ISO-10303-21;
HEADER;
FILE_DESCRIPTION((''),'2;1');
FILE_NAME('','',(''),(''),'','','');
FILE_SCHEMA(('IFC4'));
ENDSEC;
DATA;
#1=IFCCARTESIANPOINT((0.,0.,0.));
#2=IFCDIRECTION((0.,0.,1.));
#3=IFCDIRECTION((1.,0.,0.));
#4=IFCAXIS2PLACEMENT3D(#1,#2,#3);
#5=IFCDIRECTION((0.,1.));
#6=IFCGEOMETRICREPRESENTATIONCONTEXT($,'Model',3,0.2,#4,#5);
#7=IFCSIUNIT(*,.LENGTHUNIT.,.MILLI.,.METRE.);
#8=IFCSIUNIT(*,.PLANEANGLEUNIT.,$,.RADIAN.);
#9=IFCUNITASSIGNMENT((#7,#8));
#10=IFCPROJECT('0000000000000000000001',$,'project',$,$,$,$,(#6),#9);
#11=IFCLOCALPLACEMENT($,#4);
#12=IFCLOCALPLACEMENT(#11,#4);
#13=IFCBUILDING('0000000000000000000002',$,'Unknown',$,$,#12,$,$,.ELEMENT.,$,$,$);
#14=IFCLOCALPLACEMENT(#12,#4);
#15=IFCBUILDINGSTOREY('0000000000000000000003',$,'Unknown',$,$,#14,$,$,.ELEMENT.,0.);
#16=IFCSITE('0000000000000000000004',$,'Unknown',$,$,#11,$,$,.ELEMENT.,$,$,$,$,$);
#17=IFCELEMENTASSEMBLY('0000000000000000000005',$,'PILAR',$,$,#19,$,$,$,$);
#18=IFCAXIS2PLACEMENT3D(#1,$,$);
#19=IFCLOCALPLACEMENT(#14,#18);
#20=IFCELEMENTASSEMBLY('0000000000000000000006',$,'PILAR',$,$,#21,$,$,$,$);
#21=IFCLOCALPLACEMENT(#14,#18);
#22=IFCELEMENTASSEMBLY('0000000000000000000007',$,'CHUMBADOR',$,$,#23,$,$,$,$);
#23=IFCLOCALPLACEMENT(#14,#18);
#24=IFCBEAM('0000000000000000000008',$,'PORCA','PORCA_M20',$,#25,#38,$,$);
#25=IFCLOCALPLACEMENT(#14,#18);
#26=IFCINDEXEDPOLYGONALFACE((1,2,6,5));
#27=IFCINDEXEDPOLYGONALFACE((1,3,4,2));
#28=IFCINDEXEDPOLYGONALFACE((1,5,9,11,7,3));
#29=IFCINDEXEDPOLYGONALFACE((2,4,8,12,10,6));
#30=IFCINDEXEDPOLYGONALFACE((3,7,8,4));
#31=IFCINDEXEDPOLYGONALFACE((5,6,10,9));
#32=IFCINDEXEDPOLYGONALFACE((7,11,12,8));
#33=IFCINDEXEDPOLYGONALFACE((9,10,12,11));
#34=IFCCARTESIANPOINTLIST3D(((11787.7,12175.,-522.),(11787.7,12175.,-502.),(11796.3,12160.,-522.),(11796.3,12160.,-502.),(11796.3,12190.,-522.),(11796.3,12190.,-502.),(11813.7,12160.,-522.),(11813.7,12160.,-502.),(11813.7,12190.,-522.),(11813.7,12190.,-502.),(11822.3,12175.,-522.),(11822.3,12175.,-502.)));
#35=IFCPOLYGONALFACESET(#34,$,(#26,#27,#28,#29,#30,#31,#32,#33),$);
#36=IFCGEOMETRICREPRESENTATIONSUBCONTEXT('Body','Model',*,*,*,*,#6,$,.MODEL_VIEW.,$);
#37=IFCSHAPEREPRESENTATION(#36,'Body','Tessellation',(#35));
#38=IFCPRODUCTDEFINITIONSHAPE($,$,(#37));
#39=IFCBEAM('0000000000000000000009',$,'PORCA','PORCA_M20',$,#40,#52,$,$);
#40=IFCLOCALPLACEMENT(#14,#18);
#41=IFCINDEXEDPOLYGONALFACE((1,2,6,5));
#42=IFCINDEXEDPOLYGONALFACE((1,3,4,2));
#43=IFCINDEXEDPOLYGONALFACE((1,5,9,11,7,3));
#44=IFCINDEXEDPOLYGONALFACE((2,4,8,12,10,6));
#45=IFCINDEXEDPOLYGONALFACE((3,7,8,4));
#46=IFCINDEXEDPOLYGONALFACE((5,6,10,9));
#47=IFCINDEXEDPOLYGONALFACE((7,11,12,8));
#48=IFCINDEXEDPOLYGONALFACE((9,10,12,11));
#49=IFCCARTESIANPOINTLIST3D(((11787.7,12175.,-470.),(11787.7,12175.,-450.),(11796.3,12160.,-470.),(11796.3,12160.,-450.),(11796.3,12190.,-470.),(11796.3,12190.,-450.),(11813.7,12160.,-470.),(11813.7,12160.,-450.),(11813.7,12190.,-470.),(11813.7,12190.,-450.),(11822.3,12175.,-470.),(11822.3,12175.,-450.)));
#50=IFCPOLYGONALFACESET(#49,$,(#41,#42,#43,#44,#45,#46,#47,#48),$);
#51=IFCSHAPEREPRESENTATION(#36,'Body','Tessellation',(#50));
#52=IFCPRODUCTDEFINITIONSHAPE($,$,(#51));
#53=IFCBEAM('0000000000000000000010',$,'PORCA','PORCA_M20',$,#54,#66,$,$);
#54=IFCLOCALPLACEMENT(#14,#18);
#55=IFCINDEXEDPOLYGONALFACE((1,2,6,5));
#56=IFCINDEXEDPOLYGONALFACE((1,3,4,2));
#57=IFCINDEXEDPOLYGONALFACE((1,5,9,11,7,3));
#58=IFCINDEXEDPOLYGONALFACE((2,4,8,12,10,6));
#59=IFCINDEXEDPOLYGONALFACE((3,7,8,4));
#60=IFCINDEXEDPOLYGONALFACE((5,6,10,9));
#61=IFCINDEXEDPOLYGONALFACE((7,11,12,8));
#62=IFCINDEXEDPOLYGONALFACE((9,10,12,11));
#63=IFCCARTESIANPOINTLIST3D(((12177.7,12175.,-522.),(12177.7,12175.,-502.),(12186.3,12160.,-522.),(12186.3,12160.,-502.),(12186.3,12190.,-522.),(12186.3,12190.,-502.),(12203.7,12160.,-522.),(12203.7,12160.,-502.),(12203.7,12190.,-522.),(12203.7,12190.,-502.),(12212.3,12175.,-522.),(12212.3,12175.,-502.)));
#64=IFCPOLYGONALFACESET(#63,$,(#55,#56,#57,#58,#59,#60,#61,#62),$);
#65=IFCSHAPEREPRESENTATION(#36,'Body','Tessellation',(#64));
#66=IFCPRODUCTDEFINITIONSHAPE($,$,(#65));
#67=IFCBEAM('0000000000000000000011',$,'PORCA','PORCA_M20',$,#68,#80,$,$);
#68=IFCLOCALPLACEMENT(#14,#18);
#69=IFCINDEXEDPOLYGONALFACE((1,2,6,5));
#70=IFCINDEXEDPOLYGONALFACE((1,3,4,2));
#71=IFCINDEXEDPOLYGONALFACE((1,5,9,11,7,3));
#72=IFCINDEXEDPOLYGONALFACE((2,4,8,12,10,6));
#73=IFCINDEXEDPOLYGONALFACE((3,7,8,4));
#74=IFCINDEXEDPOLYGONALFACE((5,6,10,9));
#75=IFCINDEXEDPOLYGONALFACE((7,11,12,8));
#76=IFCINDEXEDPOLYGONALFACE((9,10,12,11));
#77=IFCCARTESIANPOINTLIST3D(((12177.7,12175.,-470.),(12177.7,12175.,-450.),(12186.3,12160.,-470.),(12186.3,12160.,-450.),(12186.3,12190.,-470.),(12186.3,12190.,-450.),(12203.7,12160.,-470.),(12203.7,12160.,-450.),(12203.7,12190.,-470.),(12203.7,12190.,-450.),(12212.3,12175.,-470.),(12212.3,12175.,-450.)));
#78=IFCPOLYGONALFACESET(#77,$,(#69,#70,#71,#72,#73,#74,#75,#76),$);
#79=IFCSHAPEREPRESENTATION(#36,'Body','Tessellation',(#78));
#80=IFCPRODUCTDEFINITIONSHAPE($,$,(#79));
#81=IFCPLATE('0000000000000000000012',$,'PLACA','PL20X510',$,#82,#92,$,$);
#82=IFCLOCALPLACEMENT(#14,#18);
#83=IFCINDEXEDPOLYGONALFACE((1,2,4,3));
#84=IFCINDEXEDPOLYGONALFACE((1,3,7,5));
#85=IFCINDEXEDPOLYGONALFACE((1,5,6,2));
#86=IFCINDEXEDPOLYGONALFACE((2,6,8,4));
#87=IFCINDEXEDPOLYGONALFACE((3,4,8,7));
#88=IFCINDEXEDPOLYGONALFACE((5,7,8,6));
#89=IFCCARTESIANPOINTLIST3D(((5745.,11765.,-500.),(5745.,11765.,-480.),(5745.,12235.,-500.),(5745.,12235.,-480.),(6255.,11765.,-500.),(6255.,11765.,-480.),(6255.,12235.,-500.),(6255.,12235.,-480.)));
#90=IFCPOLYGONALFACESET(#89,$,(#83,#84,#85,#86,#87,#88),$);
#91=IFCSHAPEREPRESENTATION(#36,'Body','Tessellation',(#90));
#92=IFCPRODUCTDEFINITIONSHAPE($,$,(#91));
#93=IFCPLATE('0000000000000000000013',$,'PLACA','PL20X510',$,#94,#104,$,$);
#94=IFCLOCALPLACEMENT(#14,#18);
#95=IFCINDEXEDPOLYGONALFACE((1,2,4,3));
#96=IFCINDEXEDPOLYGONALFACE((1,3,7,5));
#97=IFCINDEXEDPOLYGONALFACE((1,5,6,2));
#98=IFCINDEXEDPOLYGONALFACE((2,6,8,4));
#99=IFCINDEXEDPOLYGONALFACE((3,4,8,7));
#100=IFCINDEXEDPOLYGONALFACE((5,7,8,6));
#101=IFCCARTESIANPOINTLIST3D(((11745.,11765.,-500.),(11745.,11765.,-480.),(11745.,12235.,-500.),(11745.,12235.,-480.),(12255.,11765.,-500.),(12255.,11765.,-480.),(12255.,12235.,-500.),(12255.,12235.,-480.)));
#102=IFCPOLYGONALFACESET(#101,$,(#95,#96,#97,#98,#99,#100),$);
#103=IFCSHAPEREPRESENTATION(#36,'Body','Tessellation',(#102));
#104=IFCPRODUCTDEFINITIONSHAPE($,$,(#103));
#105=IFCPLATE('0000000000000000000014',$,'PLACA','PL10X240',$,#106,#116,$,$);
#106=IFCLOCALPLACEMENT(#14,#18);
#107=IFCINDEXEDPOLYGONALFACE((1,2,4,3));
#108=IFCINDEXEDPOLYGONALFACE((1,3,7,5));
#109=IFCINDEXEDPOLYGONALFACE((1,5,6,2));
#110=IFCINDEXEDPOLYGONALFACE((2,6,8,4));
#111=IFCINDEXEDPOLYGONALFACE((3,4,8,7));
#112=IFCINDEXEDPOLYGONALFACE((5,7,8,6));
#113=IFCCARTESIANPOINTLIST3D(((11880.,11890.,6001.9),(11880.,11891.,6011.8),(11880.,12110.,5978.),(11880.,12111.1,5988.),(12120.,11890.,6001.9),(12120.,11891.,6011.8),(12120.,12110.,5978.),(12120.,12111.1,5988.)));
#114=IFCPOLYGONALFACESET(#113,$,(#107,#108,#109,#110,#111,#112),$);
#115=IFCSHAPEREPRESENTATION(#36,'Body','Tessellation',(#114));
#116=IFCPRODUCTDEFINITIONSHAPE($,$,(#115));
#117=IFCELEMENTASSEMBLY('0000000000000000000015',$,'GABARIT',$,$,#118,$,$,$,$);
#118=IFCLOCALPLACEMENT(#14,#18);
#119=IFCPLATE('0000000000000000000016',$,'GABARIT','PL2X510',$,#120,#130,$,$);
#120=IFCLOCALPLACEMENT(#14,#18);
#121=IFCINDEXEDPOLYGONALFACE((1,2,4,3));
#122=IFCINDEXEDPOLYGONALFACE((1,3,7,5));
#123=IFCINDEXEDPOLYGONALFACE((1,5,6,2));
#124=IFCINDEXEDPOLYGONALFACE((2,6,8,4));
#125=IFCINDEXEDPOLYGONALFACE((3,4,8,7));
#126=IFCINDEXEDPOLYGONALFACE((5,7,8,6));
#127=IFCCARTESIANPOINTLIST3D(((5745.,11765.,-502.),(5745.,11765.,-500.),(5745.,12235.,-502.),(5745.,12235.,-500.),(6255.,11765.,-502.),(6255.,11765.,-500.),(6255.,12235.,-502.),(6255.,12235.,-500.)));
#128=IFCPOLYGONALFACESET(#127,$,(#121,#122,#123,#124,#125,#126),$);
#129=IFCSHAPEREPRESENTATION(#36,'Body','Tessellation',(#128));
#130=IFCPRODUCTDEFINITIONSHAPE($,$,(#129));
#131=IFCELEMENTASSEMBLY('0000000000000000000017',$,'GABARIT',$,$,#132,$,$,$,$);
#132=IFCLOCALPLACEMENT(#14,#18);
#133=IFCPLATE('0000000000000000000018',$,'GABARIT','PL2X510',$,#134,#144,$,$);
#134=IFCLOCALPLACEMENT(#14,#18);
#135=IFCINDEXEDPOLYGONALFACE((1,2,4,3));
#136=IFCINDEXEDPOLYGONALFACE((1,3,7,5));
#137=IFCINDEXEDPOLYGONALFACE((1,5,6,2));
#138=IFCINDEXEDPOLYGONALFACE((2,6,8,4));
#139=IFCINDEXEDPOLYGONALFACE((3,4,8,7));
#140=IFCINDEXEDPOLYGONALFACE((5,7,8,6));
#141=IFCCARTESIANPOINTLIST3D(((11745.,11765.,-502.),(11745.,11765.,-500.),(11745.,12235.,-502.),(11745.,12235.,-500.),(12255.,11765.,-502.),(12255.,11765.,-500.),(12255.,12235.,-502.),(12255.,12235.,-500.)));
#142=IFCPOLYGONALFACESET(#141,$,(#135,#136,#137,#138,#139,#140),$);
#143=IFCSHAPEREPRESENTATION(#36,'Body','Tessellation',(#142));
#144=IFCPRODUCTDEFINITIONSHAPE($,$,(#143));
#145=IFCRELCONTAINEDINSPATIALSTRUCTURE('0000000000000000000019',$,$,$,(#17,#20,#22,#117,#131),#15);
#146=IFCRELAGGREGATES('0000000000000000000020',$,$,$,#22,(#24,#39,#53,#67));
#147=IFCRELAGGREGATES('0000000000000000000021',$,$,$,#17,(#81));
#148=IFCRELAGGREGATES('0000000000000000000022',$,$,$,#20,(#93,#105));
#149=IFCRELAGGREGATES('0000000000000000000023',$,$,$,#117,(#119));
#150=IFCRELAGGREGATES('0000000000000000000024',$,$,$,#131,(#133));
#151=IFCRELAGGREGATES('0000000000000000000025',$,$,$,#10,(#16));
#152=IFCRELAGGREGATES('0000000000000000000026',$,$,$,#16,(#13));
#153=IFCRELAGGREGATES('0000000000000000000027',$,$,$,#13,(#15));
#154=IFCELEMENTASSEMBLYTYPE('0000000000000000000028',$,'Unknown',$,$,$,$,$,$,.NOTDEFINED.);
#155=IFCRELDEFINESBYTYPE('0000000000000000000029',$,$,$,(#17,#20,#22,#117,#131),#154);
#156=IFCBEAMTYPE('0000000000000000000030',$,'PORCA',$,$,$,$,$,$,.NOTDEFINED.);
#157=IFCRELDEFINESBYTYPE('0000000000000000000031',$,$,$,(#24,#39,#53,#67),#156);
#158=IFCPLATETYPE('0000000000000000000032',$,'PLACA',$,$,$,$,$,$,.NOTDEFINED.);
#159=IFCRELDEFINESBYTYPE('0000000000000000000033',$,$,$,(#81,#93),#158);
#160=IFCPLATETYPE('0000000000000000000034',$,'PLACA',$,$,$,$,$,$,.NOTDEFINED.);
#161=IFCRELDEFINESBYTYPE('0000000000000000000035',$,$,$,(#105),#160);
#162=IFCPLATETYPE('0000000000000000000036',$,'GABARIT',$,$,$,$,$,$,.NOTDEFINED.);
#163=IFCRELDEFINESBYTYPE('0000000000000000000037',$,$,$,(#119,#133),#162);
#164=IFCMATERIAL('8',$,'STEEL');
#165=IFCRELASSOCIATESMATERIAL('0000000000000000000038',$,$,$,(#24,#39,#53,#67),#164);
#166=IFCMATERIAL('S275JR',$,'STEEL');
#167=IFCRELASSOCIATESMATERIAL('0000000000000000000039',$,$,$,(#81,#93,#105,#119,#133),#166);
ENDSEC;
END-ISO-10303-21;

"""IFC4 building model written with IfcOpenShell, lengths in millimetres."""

from ifc_helpers import new_model, si_unit, direction, frame, origin_with_axes, origin_2d_with_axis, place, context, subcontext, project, spatial, polyline, rectangle, outline, extrude, material, material_profile, profile_set, profile_usage, type_object, element, aggregate, save


model = new_model("IFC4")

# Units and contexts
model_context = context("Model", 3, precision=0.2, world=origin_with_axes(), true_north=direction((0.0, 1.0)))
body_context = subcontext(model_context, "Body", "Model", "MODEL_VIEW")
ifc_project = project(units=[si_unit("LENGTHUNIT", "METRE", prefix="MILLI"), si_unit("PLANEANGLEUNIT", "RADIAN")], contexts=[model_context])

# Site, building, storey
site_placement = place(None, origin_with_axes())
site = spatial("IfcSite", under=ifc_project, at=site_placement, Name="Unknown", CompositionType="ELEMENT")
building_placement = place(site_placement, origin_with_axes())
building = spatial("IfcBuilding", under=site, at=building_placement, Name="Unknown", CompositionType="ELEMENT")
storey_placement = place(building_placement, origin_with_axes())
storey = spatial("IfcBuildingStorey", under=building, at=storey_placement, Name="Unknown", CompositionType="ELEMENT", Elevation=0.0)

# Element assemblies
element_assembly_type = type_object("IfcElementAssemblyType", Name="Unknown", PredefinedType="NOTDEFINED")
assembly_1_placement = place(storey_placement, frame((6000.0, 12000.0, -500.0), z_axis=(-1.0, 0.0, 0.0), x_axis=(0.0, 0.0, 1.0)))
assembly_1 = element("IfcElementAssembly", 1, at=assembly_1_placement, inside=storey, type_object=element_assembly_type, Name="PILAR")
assembly_2_placement = place(storey_placement, frame((12000.0, 12000.0, -500.0), z_axis=(-1.0, 0.0, 0.0), x_axis=(0.0, 0.0, 1.0)))
assembly_2 = element("IfcElementAssembly", 2, at=assembly_2_placement, inside=storey, type_object=element_assembly_type, Name="PILAR")

# Element assembly
ifc_material_1 = material(Name="S275JR", Category="STEEL")
assembly_3_placement = place(storey_placement, frame((12195.0, 12175.0, -555.0), z_axis=(-1.0, 0.0, 0.0), x_axis=(0.0, 0.0, -1.0)))
assembly_3 = element("IfcElementAssembly", 3, at=assembly_3_placement, inside=storey, type_object=element_assembly_type, Name="CHUMBADOR")

# Beams
ifc_material_2 = material(Name="8", Category="STEEL")
ifc_material_profile_1 = material_profile(ifc_material_2, outline(polyline([(8.7, -15.0), (17.3, 0.0), (8.7, 15.0), (-8.7, 15.0), (-17.3, 0.0), (-8.7, -15.0), (8.7, -15.0)])), Name="PORCA_M20")
ifc_profile_set_1 = profile_set([ifc_material_profile_1])
ifc_profile_usage_1 = profile_usage(ifc_profile_set_1, cardinal=5)
beam_type_1 = type_object("IfcBeamType", Name="PORCA", PredefinedType="NOTDEFINED")
beam_1_placement = place(assembly_3_placement, frame((-53.0, 0.0, 390.0), z_axis=(0.0, 0.0, 1.0), x_axis=(1.0, 0.0, 0.0)))
beam_1 = element("IfcBeam", 4, at=beam_1_placement, type_object=beam_type_1, material=ifc_profile_usage_1, Name="PORCA", Description="PORCA_M20", context=body_context, shape_type="SolidModel", body=[
    extrude(outline(polyline([(8.7, -15.0), (17.3, 0.0), (8.7, 15.0), (-8.7, 15.0), (-17.3, 0.0), (-8.7, -15.0), (8.7, -15.0)])), frame((0.0, 0.0, 0.0), z_axis=(-1.0, 0.0, 0.0), x_axis=(0.0, 0.0, 1.0)), (0.0, 0.0, -1.0), 20.0),
])
beam_2_placement = place(assembly_3_placement, frame((-105.0, 0.0, 390.0), z_axis=(0.0, 0.0, 1.0), x_axis=(1.0, 0.0, 0.0)))
beam_2 = element("IfcBeam", 5, at=beam_2_placement, type_object=beam_type_1, material=ifc_profile_usage_1, Name="PORCA", Description="PORCA_M20", context=body_context, shape_type="SolidModel", body=[
    extrude(outline(polyline([(8.7, -15.0), (17.3, 0.0), (8.7, 15.0), (-8.7, 15.0), (-17.3, 0.0), (-8.7, -15.0), (8.7, -15.0)])), frame((0.0, 0.0, 0.0), z_axis=(-1.0, 0.0, 0.0), x_axis=(0.0, 0.0, 1.0)), (0.0, 0.0, -1.0), 20.0),
])
beam_3_placement = place(assembly_3_placement, frame((-53.0, 0.0, 0.0), z_axis=(0.0, 0.0, -1.0), x_axis=(1.0, 0.0, 0.0)))
beam_3 = element("IfcBeam", 6, at=beam_3_placement, type_object=beam_type_1, material=ifc_profile_usage_1, Name="PORCA", Description="PORCA_M20", context=body_context, shape_type="SolidModel", body=[
    extrude(outline(polyline([(8.7, -15.0), (17.3, 0.0), (8.7, 15.0), (-8.7, 15.0), (-17.3, 0.0), (-8.7, -15.0), (8.7, -15.0)])), frame((0.0, 0.0, 0.0), z_axis=(-1.0, 0.0, 0.0), x_axis=(0.0, 0.0, 1.0)), (0.0, 0.0, -1.0), 20.0),
])
beam_4_placement = place(assembly_3_placement, frame((-105.0, 0.0, 0.0), z_axis=(0.0, 0.0, -1.0), x_axis=(1.0, 0.0, 0.0)))
beam_4 = element("IfcBeam", 7, at=beam_4_placement, type_object=beam_type_1, material=ifc_profile_usage_1, Name="PORCA", Description="PORCA_M20", context=body_context, shape_type="SolidModel", body=[
    extrude(outline(polyline([(8.7, -15.0), (17.3, 0.0), (8.7, 15.0), (-8.7, 15.0), (-17.3, 0.0), (-8.7, -15.0), (8.7, -15.0)])), frame((0.0, 0.0, 0.0), z_axis=(-1.0, 0.0, 0.0), x_axis=(0.0, 0.0, 1.0)), (0.0, 0.0, -1.0), 20.0),
])
aggregate(assembly_3, [beam_1, beam_2, beam_3, beam_4])

# Plates
ifc_material_profile_2 = material_profile(ifc_material_1, rectangle(XDim=470.0, YDim=510.0, at=origin_2d_with_axis()), Name="PL20X510")
ifc_profile_set_2 = profile_set([ifc_material_profile_2])
ifc_profile_usage_2 = profile_usage(ifc_profile_set_2, cardinal=8)
plate_type_1 = type_object("IfcPlateType", Name="PLACA", PredefinedType="NOTDEFINED")
plate_1_placement = place(assembly_1_placement, frame((10.0, 235.0, 0.0), z_axis=(0.0, -1.0, 0.0), x_axis=(1.0, 0.0, 0.0)))
plate_1 = element("IfcPlate", 8, at=plate_1_placement, type_object=plate_type_1, material=ifc_profile_usage_2, Name="PLACA", Description="PL20X510", context=body_context, shape_type="SolidModel", body=[
    extrude(rectangle(XDim=470.0, YDim=510.0, at=origin_2d_with_axis()), frame((-10.0, 0.0, 235.0), z_axis=(-1.0, 0.0, 0.0), x_axis=(0.0, 0.0, 1.0)), (0.0, 0.0, -1.0), 20.0),
])
aggregate(assembly_1, [plate_1])
plate_2_placement = place(assembly_2_placement, frame((10.0, 235.0, 0.0), z_axis=(0.0, -1.0, 0.0), x_axis=(1.0, 0.0, 0.0)))
plate_2 = element("IfcPlate", 9, at=plate_2_placement, type_object=plate_type_1, material=ifc_profile_usage_2, Name="PLACA", Description="PL20X510", context=body_context, shape_type="SolidModel", body=[
    extrude(rectangle(XDim=470.0, YDim=510.0, at=origin_2d_with_axis()), frame((-10.0, 0.0, 235.0), z_axis=(-1.0, 0.0, 0.0), x_axis=(0.0, 0.0, 1.0)), (0.0, 0.0, -1.0), 20.0),
])
ifc_material_profile_3 = material_profile(ifc_material_1, rectangle(XDim=221.3, YDim=240.0, at=origin_2d_with_axis()), Name="PL10X240")
ifc_profile_set_3 = profile_set([ifc_material_profile_3])
ifc_profile_usage_3 = profile_usage(ifc_profile_set_3, cardinal=2)
plate_type_2 = type_object("IfcPlateType", Name="PLACA", PredefinedType="NOTDEFINED")
plate_3_placement = place(assembly_2_placement, frame((6506.8, -109.5, 0.0), z_axis=(-0.107703, 0.994183, 0.0), x_axis=(-0.994183, -0.107703, 0.0)))
plate_3 = element("IfcPlate", 10, at=plate_3_placement, type_object=plate_type_2, material=ifc_profile_usage_3, Name="PLACA", Description="PL10X240", context=body_context, shape_type="SolidModel", body=[
    extrude(rectangle(XDim=221.3, YDim=240.0, at=origin_2d_with_axis()), frame((-5.0, 0.0, 110.7), z_axis=(-1.0, 0.0, 0.0), x_axis=(0.0, 0.0, 1.0)), (0.0, 0.0, -1.0), 10.0),
])
aggregate(assembly_2, [plate_2, plate_3])

# Element assemblies, plates
assembly_4_placement = place(storey_placement, frame((6000.0, 11765.0, -501.0), z_axis=(0.0, 0.0, 1.0), x_axis=(0.0, 1.0, 0.0)))
assembly_4 = element("IfcElementAssembly", 11, at=assembly_4_placement, inside=storey, type_object=element_assembly_type, Name="GABARIT")
ifc_material_profile_4 = material_profile(ifc_material_1, rectangle(XDim=470.0, YDim=510.0, at=origin_2d_with_axis()), Name="PL2X510")
ifc_profile_set_4 = profile_set([ifc_material_profile_4])
ifc_profile_usage_4 = profile_usage(ifc_profile_set_4, cardinal=2)
plate_type_3 = type_object("IfcPlateType", Name="GABARIT", PredefinedType="NOTDEFINED")
plate_4_placement = place(assembly_4_placement, frame((470.0, 0.0, 0.0), z_axis=(-1.0, 0.0, 0.0), x_axis=(0.0, 0.0, 1.0)))
plate_4 = element("IfcPlate", 12, at=plate_4_placement, type_object=plate_type_3, material=ifc_profile_usage_4, Name="GABARIT", Description="PL2X510", context=body_context, shape_type="SolidModel", body=[
    extrude(rectangle(XDim=470.0, YDim=510.0, at=origin_2d_with_axis()), frame((-1.0, 0.0, 235.0), z_axis=(-1.0, 0.0, 0.0), x_axis=(0.0, 0.0, 1.0)), (0.0, 0.0, -1.0), 2.0),
])
aggregate(assembly_4, [plate_4])
assembly_5_placement = place(storey_placement, frame((12000.0, 11765.0, -501.0), z_axis=(0.0, 0.0, 1.0), x_axis=(0.0, 1.0, 0.0)))
assembly_5 = element("IfcElementAssembly", 13, at=assembly_5_placement, inside=storey, type_object=element_assembly_type, Name="GABARIT")
plate_5_placement = place(assembly_5_placement, frame((470.0, 0.0, 0.0), z_axis=(-1.0, 0.0, 0.0), x_axis=(0.0, 0.0, 1.0)))
plate_5 = element("IfcPlate", 14, at=plate_5_placement, type_object=plate_type_3, material=ifc_profile_usage_4, Name="GABARIT", Description="PL2X510", context=body_context, shape_type="SolidModel", body=[
    extrude(rectangle(XDim=470.0, YDim=510.0, at=origin_2d_with_axis()), frame((-1.0, 0.0, 235.0), z_axis=(-1.0, 0.0, 0.0), x_axis=(0.0, 0.0, 1.0)), (0.0, 0.0, -1.0), 2.0),
])
aggregate(assembly_5, [plate_5])

save(model, "model.ifc")
